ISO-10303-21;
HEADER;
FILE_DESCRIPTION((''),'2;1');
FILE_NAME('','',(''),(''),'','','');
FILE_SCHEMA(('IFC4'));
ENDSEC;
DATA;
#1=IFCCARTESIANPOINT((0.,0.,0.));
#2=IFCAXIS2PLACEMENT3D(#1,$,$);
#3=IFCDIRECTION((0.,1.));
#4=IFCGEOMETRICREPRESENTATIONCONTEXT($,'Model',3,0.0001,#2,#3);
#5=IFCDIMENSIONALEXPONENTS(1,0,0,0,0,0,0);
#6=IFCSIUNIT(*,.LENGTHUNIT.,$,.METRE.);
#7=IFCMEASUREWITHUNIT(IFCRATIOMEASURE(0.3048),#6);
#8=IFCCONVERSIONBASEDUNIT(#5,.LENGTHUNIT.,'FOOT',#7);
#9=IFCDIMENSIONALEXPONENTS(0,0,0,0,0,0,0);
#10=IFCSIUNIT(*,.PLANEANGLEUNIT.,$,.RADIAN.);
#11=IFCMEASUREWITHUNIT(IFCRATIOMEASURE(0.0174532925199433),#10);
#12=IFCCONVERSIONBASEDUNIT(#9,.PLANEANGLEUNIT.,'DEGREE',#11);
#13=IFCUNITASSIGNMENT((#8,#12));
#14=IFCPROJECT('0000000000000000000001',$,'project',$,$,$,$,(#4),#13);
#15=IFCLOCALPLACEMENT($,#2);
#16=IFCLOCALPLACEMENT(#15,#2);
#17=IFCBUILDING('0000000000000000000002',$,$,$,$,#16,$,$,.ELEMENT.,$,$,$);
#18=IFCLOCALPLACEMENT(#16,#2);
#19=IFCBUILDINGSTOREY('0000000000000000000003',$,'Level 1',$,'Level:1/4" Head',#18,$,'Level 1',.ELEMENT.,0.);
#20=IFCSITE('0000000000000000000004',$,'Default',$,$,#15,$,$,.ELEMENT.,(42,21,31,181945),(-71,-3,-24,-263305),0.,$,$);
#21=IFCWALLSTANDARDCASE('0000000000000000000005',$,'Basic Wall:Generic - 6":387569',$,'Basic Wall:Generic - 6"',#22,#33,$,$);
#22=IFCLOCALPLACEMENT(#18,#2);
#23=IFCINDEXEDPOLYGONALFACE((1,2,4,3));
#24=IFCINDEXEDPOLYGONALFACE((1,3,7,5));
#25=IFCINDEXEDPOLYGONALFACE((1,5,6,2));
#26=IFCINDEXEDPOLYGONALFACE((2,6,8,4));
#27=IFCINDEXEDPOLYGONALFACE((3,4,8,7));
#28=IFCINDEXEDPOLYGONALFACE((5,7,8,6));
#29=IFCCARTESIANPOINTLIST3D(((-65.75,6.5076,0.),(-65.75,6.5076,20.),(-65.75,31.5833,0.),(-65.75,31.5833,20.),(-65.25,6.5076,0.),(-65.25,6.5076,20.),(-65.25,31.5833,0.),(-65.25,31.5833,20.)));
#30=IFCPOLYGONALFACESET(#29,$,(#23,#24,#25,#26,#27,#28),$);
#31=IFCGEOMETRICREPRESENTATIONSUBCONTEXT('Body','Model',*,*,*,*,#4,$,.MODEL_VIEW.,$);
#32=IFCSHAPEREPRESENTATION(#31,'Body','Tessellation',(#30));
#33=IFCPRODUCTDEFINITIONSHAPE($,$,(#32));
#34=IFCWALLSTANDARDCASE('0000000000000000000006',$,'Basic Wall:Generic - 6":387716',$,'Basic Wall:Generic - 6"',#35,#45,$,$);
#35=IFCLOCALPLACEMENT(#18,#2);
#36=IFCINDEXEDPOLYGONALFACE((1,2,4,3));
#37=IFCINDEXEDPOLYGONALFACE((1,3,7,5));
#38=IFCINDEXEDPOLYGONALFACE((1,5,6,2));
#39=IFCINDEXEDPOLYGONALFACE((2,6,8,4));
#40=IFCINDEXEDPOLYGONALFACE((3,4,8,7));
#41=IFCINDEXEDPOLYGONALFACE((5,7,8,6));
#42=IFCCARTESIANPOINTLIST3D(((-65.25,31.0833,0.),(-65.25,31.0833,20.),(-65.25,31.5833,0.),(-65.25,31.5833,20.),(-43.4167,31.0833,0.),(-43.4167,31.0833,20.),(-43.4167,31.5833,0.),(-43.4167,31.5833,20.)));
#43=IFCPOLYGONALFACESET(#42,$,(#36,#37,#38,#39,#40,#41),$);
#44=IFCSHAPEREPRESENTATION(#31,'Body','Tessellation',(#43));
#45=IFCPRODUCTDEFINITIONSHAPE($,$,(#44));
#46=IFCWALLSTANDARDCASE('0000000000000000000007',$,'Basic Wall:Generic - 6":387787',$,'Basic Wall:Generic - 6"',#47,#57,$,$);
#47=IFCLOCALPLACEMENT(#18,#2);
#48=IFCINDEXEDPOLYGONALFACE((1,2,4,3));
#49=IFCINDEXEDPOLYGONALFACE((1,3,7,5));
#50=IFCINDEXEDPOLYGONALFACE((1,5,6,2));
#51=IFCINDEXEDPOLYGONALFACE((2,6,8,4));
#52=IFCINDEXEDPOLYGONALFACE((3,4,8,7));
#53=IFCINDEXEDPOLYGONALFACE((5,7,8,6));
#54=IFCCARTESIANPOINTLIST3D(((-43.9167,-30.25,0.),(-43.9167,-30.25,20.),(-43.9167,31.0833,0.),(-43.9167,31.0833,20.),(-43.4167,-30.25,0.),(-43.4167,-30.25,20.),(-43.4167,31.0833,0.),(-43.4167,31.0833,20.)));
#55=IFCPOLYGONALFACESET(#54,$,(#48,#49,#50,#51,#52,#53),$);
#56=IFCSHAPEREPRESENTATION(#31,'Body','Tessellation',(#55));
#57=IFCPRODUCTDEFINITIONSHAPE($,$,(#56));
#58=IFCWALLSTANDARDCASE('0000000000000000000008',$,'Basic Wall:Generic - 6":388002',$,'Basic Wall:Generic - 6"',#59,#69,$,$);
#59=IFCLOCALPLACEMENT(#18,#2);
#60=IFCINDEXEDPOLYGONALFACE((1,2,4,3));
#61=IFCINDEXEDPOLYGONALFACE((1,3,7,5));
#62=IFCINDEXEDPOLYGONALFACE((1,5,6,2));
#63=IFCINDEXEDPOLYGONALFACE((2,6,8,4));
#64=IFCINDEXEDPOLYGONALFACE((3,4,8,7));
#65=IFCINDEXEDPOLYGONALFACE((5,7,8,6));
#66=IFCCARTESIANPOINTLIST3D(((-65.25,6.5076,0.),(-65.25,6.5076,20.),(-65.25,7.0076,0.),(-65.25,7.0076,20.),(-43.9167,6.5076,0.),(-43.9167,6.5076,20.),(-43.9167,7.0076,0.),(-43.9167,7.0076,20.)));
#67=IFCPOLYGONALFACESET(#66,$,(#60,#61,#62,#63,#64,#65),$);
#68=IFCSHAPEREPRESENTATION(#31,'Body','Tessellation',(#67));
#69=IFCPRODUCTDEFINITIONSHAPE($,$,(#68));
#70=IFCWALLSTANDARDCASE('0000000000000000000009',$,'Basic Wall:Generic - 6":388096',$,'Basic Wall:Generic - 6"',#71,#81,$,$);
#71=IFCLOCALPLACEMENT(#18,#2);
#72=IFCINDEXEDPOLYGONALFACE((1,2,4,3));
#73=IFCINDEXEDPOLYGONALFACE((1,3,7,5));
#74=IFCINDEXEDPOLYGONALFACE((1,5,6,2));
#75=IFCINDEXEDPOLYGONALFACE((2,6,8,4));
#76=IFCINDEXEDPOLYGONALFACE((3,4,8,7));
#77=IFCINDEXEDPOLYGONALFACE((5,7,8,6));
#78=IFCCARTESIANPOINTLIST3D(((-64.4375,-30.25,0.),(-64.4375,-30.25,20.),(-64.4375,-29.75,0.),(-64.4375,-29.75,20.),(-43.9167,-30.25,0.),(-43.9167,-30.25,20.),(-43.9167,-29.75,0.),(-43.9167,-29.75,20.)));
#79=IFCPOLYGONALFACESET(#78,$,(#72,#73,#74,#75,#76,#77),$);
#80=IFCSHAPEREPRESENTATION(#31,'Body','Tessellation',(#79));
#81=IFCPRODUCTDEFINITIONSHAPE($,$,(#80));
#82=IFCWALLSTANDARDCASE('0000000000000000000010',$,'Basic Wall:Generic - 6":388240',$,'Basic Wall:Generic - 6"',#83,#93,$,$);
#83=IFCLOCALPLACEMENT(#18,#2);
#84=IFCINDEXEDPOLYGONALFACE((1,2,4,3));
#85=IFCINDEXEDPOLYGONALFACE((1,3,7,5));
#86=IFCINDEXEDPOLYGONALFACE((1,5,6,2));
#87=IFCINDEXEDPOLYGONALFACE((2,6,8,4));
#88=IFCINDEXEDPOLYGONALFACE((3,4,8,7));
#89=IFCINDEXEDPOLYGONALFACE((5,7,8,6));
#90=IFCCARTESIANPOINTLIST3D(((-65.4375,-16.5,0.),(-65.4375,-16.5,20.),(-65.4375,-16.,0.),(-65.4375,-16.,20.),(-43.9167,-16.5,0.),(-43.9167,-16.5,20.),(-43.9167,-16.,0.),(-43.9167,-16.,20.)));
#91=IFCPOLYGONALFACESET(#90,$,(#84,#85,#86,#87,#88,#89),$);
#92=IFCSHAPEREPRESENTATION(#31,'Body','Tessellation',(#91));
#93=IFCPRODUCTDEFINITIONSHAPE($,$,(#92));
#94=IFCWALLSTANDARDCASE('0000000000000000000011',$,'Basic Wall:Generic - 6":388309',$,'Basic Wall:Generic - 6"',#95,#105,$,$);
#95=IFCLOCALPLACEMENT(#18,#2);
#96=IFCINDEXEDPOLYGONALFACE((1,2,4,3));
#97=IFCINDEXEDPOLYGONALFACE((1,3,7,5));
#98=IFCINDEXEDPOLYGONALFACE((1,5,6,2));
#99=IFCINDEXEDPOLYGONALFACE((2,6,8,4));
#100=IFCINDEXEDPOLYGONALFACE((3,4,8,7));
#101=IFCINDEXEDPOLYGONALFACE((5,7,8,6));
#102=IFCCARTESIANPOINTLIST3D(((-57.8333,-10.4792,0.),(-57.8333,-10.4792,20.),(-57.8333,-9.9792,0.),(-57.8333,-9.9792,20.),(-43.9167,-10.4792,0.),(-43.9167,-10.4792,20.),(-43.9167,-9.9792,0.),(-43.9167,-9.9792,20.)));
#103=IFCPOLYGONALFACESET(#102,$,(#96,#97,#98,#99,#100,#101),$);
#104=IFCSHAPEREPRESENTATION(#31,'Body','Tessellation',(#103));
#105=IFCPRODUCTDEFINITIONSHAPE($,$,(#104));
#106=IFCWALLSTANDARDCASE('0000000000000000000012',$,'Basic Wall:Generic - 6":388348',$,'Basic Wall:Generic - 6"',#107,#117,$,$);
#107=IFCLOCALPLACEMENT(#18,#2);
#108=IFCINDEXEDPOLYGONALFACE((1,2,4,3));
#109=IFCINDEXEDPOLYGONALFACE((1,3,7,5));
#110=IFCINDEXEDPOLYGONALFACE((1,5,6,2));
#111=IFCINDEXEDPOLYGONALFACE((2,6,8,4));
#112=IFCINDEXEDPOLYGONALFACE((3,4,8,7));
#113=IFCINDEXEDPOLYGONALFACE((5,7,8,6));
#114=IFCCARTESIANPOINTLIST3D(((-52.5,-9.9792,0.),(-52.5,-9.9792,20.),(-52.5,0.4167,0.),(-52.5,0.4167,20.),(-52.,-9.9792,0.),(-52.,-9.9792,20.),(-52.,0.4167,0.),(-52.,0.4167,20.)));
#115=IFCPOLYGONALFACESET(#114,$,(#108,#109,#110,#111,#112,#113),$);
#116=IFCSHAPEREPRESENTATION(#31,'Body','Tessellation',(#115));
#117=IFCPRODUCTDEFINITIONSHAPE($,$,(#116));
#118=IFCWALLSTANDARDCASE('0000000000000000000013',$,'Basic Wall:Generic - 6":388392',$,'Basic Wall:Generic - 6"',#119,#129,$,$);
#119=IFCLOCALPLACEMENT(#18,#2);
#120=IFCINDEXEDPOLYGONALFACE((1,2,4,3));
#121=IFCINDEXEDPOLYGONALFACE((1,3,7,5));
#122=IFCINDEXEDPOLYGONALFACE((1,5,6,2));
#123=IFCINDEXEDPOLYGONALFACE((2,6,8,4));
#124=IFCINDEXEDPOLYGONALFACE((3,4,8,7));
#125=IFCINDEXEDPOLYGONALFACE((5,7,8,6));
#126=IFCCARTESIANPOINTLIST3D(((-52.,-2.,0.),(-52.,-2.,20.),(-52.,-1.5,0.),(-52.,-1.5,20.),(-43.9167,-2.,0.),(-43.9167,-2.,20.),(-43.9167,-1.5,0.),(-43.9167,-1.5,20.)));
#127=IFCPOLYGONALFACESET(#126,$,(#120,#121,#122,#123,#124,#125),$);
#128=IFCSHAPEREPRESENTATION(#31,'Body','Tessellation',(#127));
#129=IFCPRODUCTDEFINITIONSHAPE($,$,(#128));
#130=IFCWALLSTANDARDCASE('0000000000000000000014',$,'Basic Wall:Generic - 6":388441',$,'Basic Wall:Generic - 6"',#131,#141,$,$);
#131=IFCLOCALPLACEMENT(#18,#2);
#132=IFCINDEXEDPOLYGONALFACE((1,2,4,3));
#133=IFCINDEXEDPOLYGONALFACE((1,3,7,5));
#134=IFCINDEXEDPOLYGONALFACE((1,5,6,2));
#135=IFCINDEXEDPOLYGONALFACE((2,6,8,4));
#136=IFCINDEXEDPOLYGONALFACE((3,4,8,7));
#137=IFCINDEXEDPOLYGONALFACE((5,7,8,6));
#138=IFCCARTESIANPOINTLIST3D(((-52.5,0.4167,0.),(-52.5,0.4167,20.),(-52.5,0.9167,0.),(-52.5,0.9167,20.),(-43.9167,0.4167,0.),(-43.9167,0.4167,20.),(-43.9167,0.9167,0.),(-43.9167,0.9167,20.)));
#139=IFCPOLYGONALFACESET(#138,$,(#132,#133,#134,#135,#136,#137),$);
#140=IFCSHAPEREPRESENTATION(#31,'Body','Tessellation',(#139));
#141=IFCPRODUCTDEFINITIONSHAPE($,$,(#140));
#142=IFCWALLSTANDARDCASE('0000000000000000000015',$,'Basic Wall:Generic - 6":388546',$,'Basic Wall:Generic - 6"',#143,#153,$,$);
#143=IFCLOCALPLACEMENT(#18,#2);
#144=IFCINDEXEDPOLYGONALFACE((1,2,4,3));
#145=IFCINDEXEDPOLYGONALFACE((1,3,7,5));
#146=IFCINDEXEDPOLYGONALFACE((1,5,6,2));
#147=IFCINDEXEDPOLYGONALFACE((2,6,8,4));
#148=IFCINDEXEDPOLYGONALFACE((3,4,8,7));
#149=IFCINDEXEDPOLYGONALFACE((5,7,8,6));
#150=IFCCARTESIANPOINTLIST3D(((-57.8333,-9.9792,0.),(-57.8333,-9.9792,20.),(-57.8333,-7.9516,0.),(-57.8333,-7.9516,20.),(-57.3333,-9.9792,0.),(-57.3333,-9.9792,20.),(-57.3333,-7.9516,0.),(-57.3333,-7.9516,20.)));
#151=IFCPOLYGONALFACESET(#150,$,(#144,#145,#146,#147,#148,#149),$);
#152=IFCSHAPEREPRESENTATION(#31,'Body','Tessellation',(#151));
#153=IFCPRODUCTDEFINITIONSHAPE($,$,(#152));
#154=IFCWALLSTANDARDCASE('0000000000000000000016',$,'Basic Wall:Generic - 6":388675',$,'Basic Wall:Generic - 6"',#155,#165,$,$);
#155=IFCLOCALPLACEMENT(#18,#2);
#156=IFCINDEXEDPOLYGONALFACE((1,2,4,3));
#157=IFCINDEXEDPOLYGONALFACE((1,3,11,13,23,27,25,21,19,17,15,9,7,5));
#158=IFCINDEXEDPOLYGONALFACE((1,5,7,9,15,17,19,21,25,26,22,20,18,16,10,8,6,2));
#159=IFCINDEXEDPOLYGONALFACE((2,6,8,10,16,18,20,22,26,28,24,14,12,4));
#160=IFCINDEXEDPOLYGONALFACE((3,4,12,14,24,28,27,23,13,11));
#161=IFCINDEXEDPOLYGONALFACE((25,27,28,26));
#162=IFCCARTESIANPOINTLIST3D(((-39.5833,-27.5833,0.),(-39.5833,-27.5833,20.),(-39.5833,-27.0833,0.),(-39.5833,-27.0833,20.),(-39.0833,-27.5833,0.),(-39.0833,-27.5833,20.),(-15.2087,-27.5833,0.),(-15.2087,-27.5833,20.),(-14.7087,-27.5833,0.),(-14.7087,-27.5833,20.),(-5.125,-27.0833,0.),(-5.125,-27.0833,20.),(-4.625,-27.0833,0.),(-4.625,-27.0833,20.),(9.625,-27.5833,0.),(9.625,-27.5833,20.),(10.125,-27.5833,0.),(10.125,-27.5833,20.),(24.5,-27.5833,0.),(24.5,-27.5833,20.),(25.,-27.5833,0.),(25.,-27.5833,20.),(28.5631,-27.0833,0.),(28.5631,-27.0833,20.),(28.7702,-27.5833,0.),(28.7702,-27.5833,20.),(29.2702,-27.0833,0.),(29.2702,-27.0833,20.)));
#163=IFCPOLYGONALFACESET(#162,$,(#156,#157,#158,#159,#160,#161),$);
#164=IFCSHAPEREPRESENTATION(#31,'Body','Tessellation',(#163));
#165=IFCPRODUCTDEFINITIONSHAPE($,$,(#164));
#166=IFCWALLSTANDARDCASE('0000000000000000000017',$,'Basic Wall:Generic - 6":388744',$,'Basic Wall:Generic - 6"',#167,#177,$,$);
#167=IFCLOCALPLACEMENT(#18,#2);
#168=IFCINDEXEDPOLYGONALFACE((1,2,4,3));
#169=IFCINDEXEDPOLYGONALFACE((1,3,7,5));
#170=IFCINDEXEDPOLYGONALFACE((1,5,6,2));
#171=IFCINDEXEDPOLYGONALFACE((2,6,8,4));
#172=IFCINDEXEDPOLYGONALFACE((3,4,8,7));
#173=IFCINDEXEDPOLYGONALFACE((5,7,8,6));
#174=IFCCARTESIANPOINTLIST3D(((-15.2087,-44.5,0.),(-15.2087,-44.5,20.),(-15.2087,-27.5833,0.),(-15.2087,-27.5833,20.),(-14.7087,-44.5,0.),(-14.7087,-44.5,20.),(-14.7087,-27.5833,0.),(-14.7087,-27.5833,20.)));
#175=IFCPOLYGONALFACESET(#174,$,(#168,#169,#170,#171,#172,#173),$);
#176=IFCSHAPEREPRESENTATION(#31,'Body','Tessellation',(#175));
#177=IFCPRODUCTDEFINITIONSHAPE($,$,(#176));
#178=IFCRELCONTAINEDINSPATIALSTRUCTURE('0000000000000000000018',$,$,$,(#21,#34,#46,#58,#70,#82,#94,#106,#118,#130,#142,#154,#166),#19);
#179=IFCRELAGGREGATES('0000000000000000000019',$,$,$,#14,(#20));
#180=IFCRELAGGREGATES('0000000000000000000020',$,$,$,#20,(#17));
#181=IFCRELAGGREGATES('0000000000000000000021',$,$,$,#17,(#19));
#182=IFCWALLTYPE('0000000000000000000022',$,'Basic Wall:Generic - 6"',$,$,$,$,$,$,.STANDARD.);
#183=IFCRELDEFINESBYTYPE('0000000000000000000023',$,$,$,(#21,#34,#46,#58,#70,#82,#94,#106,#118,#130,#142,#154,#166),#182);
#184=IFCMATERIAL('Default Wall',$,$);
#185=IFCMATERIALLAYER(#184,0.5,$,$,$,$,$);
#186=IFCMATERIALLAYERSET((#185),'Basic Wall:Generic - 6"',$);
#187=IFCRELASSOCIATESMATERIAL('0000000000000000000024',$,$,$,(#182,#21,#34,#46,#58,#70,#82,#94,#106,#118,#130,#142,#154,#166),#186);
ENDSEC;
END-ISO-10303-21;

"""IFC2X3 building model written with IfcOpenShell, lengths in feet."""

from ifc_helpers import new_model, entity, si_unit, converted_unit, direction, frame, frame_2d, origin, place, context, subcontext, project, spatial, polyline, rectangle, outline, extrude, material, layer, layer_set, layer_usage, type_object, element, save


model = new_model("IFC2X3")

# Units and contexts
model_context = context("Model", 3, precision=0.0001, world=origin(), true_north=direction((0.0, 1.0)))
body_context = subcontext(model_context, "Body", "Model", "MODEL_VIEW")
ifc_project = project(units=[converted_unit("LENGTHUNIT", "FOOT", entity("IfcRatioMeasure", 0.3048), si_unit("LENGTHUNIT", "METRE"), dimensions=[1, 0, 0, 0, 0, 0, 0]), converted_unit("PLANEANGLEUNIT", "DEGREE", entity("IfcRatioMeasure", 0.0174532925199433), si_unit("PLANEANGLEUNIT", "RADIAN"), dimensions=[0, 0, 0, 0, 0, 0, 0])], contexts=[model_context])

# Site, building, storey
site_placement = place(None, origin())
site = spatial("IfcSite", under=ifc_project, at=site_placement, Name="Default", CompositionType="ELEMENT", RefLatitude=(42, 21, 31, 181945), RefLongitude=(-71, -3, -24, -263305), RefElevation=0.0)
building_placement = place(site_placement, origin())
building = spatial("IfcBuilding", under=site, at=building_placement, CompositionType="ELEMENT")
storey_placement = place(building_placement, origin())
storey = spatial("IfcBuildingStorey", under=building, at=storey_placement, Name="Level 1", ObjectType="Level:1/4\" Head", LongName="Level 1", CompositionType="ELEMENT", Elevation=0.0)

# Walls
ifc_material = material(Name="Default Wall")
ifc_layer_1 = layer(ifc_material, 0.5)
ifc_layer_set_1 = layer_set([ifc_layer_1], Name="Basic Wall:Generic - 6\"")
wall_type_1 = type_object("IfcWallType", Name="Basic Wall:Generic - 6\"", PredefinedType="STANDARD", material=ifc_layer_set_1)
ifc_layer_usage_1 = layer_usage(ifc_layer_set_1, "AXIS2", "NEGATIVE", 0.25)
wall_1_placement = place(storey_placement, frame((-65.5, 6.5076, 0.0), z_axis=(0.0, 0.0, 1.0), x_axis=(0.0, 1.0, 0.0)))
element("IfcWallStandardCase", 1, at=wall_1_placement, inside=storey, type_object=wall_type_1, material=ifc_layer_usage_1, Name="Basic Wall:Generic - 6\":387569", ObjectType="Basic Wall:Generic - 6\"", context=body_context, shape_type="SweptSolid", body=[
    extrude(rectangle(XDim=25.0757, YDim=0.5, at=frame_2d((12.5378, 0.0), x_axis=(-1.0, 0.0))), origin(), (0.0, 0.0, 1.0), 20.0),
])
ifc_layer_usage_2 = layer_usage(ifc_layer_set_1, "AXIS2", "NEGATIVE", 0.25)
wall_2_placement = place(storey_placement, frame((-65.25, 31.3333, 0.0)))
element("IfcWallStandardCase", 2, at=wall_2_placement, inside=storey, type_object=wall_type_1, material=ifc_layer_usage_2, Name="Basic Wall:Generic - 6\":387716", ObjectType="Basic Wall:Generic - 6\"", context=body_context, shape_type="SweptSolid", body=[
    extrude(rectangle(XDim=21.8333, YDim=0.5, at=frame_2d((10.9167, 0.0), x_axis=(-1.0, 0.0))), origin(), (0.0, 0.0, 1.0), 20.0),
])
ifc_layer_usage_3 = layer_usage(ifc_layer_set_1, "AXIS2", "NEGATIVE", 0.25)
wall_3_placement = place(storey_placement, frame((-43.6667, 31.0833, 0.0), z_axis=(0.0, 0.0, 1.0), x_axis=(0.0, -1.0, 0.0)))
element("IfcWallStandardCase", 3, at=wall_3_placement, inside=storey, type_object=wall_type_1, material=ifc_layer_usage_3, Name="Basic Wall:Generic - 6\":387787", ObjectType="Basic Wall:Generic - 6\"", context=body_context, shape_type="SweptSolid", body=[
    extrude(rectangle(XDim=61.3333, YDim=0.5, at=frame_2d((30.6667, 0.0), x_axis=(-1.0, 0.0))), origin(), (0.0, 0.0, 1.0), 20.0),
])
ifc_layer_usage_4 = layer_usage(ifc_layer_set_1, "AXIS2", "NEGATIVE", 0.25)
wall_4_placement = place(storey_placement, frame((-65.25, 6.7576, 0.0)))
element("IfcWallStandardCase", 4, at=wall_4_placement, inside=storey, type_object=wall_type_1, material=ifc_layer_usage_4, Name="Basic Wall:Generic - 6\":388002", ObjectType="Basic Wall:Generic - 6\"", context=body_context, shape_type="SweptSolid", body=[
    extrude(rectangle(XDim=21.3333, YDim=0.5, at=frame_2d((10.6667, 0.0), x_axis=(-1.0, 0.0))), origin(), (0.0, 0.0, 1.0), 20.0),
])
ifc_layer_usage_5 = layer_usage(ifc_layer_set_1, "AXIS2", "NEGATIVE", 0.25)
wall_5_placement = place(storey_placement, frame((-43.9167, -30.0, 0.0), z_axis=(0.0, 0.0, 1.0), x_axis=(-1.0, 0.0, 0.0)))
element("IfcWallStandardCase", 5, at=wall_5_placement, inside=storey, type_object=wall_type_1, material=ifc_layer_usage_5, Name="Basic Wall:Generic - 6\":388096", ObjectType="Basic Wall:Generic - 6\"", context=body_context, shape_type="SweptSolid", body=[
    extrude(rectangle(XDim=20.5208, YDim=0.5, at=frame_2d((10.2604, 0.0), x_axis=(-1.0, 0.0))), origin(), (0.0, 0.0, 1.0), 20.0),
])
ifc_layer_usage_6 = layer_usage(ifc_layer_set_1, "AXIS2", "NEGATIVE", 0.25)
wall_6_placement = place(storey_placement, frame((-43.9167, -16.25, 0.0), z_axis=(0.0, 0.0, 1.0), x_axis=(-1.0, 0.0, 0.0)))
element("IfcWallStandardCase", 6, at=wall_6_placement, inside=storey, type_object=wall_type_1, material=ifc_layer_usage_6, Name="Basic Wall:Generic - 6\":388240", ObjectType="Basic Wall:Generic - 6\"", context=body_context, shape_type="SweptSolid", body=[
    extrude(rectangle(XDim=21.5208, YDim=0.5, at=frame_2d((10.7604, 0.0), x_axis=(-1.0, 0.0))), origin(), (0.0, 0.0, 1.0), 20.0),
])
ifc_layer_usage_7 = layer_usage(ifc_layer_set_1, "AXIS2", "NEGATIVE", 0.25)
wall_7_placement = place(storey_placement, frame((-43.9167, -10.2292, 0.0), z_axis=(0.0, 0.0, 1.0), x_axis=(-1.0, 0.0, 0.0)))
element("IfcWallStandardCase", 7, at=wall_7_placement, inside=storey, type_object=wall_type_1, material=ifc_layer_usage_7, Name="Basic Wall:Generic - 6\":388309", ObjectType="Basic Wall:Generic - 6\"", context=body_context, shape_type="SweptSolid", body=[
    extrude(rectangle(XDim=13.9167, YDim=0.5, at=frame_2d((6.9583, 0.0), x_axis=(-1.0, 0.0))), origin(), (0.0, 0.0, 1.0), 20.0),
])
ifc_layer_usage_8 = layer_usage(ifc_layer_set_1, "AXIS2", "NEGATIVE", 0.25)
wall_8_placement = place(storey_placement, frame((-52.25, -9.9792, 0.0), z_axis=(0.0, 0.0, 1.0), x_axis=(0.0, 1.0, 0.0)))
element("IfcWallStandardCase", 8, at=wall_8_placement, inside=storey, type_object=wall_type_1, material=ifc_layer_usage_8, Name="Basic Wall:Generic - 6\":388348", ObjectType="Basic Wall:Generic - 6\"", context=body_context, shape_type="SweptSolid", body=[
    extrude(rectangle(XDim=10.3958, YDim=0.5, at=frame_2d((5.1979, 0.0), x_axis=(-1.0, 0.0))), origin(), (0.0, 0.0, 1.0), 20.0),
])
ifc_layer_usage_9 = layer_usage(ifc_layer_set_1, "AXIS2", "NEGATIVE", 0.25)
wall_9_placement = place(storey_placement, frame((-52.0, -1.75, 0.0)))
element("IfcWallStandardCase", 9, at=wall_9_placement, inside=storey, type_object=wall_type_1, material=ifc_layer_usage_9, Name="Basic Wall:Generic - 6\":388392", ObjectType="Basic Wall:Generic - 6\"", context=body_context, shape_type="SweptSolid", body=[
    extrude(rectangle(XDim=8.0833, YDim=0.5, at=frame_2d((4.0417, 0.0), x_axis=(-1.0, 0.0))), origin(), (0.0, 0.0, 1.0), 20.0),
])
ifc_layer_usage_10 = layer_usage(ifc_layer_set_1, "AXIS2", "NEGATIVE", 0.25)
wall_10_placement = place(storey_placement, frame((-43.9167, 0.6667, 0.0), z_axis=(0.0, 0.0, 1.0), x_axis=(-1.0, 0.0, 0.0)))
element("IfcWallStandardCase", 10, at=wall_10_placement, inside=storey, type_object=wall_type_1, material=ifc_layer_usage_10, Name="Basic Wall:Generic - 6\":388441", ObjectType="Basic Wall:Generic - 6\"", context=body_context, shape_type="SweptSolid", body=[
    extrude(rectangle(XDim=8.5833, YDim=0.5, at=frame_2d((4.2917, 0.0), x_axis=(-1.0, 0.0))), origin(), (0.0, 0.0, 1.0), 20.0),
])
ifc_layer_usage_11 = layer_usage(ifc_layer_set_1, "AXIS2", "NEGATIVE", 0.25)
wall_11_placement = place(storey_placement, frame((-57.5833, -9.9792, 0.0), z_axis=(0.0, 0.0, 1.0), x_axis=(0.0, 1.0, 0.0)))
element("IfcWallStandardCase", 11, at=wall_11_placement, inside=storey, type_object=wall_type_1, material=ifc_layer_usage_11, Name="Basic Wall:Generic - 6\":388546", ObjectType="Basic Wall:Generic - 6\"", context=body_context, shape_type="SweptSolid", body=[
    extrude(rectangle(XDim=2.0276, YDim=0.5, at=frame_2d((1.0138, 0.0), x_axis=(-1.0, 0.0))), origin(), (0.0, 0.0, 1.0), 20.0),
])
ifc_layer_usage_12 = layer_usage(ifc_layer_set_1, "AXIS2", "NEGATIVE", 0.25)
wall_12_placement = place(storey_placement, frame((-39.5833, -27.3333, 0.0)))
element("IfcWallStandardCase", 12, at=wall_12_placement, inside=storey, type_object=wall_type_1, material=ifc_layer_usage_12, Name="Basic Wall:Generic - 6\":388675", ObjectType="Basic Wall:Generic - 6\"", context=body_context, shape_type="SweptSolid", body=[
    extrude(outline(polyline([(68.3536, -0.25), (68.8536, 0.25), (68.1464, 0.25), (34.9583, 0.25), (34.4583, 0.25), (0.0, 0.25), (0.0, -0.25), (0.5, -0.25), (24.3746, -0.25), (24.8746, -0.25), (49.2083, -0.25), (49.7083, -0.25), (64.0833, -0.25), (64.5833, -0.25), (68.3536, -0.25)])), origin(), (0.0, 0.0, 1.0), 20.0),
])
ifc_layer_usage_13 = layer_usage(ifc_layer_set_1, "AXIS2", "NEGATIVE", 0.25)
wall_13_placement = place(storey_placement, frame((-14.9587, -27.5833, 0.0), z_axis=(0.0, 0.0, 1.0), x_axis=(0.0, -1.0, 0.0)))
element("IfcWallStandardCase", 13, at=wall_13_placement, inside=storey, type_object=wall_type_1, material=ifc_layer_usage_13, Name="Basic Wall:Generic - 6\":388744", ObjectType="Basic Wall:Generic - 6\"", context=body_context, shape_type="SweptSolid", body=[
    extrude(rectangle(XDim=16.9167, YDim=0.5, at=frame_2d((8.4583, 0.0), x_axis=(-1.0, 0.0))), origin(), (0.0, 0.0, 1.0), 20.0),
])

save(model, "model.ifc")
